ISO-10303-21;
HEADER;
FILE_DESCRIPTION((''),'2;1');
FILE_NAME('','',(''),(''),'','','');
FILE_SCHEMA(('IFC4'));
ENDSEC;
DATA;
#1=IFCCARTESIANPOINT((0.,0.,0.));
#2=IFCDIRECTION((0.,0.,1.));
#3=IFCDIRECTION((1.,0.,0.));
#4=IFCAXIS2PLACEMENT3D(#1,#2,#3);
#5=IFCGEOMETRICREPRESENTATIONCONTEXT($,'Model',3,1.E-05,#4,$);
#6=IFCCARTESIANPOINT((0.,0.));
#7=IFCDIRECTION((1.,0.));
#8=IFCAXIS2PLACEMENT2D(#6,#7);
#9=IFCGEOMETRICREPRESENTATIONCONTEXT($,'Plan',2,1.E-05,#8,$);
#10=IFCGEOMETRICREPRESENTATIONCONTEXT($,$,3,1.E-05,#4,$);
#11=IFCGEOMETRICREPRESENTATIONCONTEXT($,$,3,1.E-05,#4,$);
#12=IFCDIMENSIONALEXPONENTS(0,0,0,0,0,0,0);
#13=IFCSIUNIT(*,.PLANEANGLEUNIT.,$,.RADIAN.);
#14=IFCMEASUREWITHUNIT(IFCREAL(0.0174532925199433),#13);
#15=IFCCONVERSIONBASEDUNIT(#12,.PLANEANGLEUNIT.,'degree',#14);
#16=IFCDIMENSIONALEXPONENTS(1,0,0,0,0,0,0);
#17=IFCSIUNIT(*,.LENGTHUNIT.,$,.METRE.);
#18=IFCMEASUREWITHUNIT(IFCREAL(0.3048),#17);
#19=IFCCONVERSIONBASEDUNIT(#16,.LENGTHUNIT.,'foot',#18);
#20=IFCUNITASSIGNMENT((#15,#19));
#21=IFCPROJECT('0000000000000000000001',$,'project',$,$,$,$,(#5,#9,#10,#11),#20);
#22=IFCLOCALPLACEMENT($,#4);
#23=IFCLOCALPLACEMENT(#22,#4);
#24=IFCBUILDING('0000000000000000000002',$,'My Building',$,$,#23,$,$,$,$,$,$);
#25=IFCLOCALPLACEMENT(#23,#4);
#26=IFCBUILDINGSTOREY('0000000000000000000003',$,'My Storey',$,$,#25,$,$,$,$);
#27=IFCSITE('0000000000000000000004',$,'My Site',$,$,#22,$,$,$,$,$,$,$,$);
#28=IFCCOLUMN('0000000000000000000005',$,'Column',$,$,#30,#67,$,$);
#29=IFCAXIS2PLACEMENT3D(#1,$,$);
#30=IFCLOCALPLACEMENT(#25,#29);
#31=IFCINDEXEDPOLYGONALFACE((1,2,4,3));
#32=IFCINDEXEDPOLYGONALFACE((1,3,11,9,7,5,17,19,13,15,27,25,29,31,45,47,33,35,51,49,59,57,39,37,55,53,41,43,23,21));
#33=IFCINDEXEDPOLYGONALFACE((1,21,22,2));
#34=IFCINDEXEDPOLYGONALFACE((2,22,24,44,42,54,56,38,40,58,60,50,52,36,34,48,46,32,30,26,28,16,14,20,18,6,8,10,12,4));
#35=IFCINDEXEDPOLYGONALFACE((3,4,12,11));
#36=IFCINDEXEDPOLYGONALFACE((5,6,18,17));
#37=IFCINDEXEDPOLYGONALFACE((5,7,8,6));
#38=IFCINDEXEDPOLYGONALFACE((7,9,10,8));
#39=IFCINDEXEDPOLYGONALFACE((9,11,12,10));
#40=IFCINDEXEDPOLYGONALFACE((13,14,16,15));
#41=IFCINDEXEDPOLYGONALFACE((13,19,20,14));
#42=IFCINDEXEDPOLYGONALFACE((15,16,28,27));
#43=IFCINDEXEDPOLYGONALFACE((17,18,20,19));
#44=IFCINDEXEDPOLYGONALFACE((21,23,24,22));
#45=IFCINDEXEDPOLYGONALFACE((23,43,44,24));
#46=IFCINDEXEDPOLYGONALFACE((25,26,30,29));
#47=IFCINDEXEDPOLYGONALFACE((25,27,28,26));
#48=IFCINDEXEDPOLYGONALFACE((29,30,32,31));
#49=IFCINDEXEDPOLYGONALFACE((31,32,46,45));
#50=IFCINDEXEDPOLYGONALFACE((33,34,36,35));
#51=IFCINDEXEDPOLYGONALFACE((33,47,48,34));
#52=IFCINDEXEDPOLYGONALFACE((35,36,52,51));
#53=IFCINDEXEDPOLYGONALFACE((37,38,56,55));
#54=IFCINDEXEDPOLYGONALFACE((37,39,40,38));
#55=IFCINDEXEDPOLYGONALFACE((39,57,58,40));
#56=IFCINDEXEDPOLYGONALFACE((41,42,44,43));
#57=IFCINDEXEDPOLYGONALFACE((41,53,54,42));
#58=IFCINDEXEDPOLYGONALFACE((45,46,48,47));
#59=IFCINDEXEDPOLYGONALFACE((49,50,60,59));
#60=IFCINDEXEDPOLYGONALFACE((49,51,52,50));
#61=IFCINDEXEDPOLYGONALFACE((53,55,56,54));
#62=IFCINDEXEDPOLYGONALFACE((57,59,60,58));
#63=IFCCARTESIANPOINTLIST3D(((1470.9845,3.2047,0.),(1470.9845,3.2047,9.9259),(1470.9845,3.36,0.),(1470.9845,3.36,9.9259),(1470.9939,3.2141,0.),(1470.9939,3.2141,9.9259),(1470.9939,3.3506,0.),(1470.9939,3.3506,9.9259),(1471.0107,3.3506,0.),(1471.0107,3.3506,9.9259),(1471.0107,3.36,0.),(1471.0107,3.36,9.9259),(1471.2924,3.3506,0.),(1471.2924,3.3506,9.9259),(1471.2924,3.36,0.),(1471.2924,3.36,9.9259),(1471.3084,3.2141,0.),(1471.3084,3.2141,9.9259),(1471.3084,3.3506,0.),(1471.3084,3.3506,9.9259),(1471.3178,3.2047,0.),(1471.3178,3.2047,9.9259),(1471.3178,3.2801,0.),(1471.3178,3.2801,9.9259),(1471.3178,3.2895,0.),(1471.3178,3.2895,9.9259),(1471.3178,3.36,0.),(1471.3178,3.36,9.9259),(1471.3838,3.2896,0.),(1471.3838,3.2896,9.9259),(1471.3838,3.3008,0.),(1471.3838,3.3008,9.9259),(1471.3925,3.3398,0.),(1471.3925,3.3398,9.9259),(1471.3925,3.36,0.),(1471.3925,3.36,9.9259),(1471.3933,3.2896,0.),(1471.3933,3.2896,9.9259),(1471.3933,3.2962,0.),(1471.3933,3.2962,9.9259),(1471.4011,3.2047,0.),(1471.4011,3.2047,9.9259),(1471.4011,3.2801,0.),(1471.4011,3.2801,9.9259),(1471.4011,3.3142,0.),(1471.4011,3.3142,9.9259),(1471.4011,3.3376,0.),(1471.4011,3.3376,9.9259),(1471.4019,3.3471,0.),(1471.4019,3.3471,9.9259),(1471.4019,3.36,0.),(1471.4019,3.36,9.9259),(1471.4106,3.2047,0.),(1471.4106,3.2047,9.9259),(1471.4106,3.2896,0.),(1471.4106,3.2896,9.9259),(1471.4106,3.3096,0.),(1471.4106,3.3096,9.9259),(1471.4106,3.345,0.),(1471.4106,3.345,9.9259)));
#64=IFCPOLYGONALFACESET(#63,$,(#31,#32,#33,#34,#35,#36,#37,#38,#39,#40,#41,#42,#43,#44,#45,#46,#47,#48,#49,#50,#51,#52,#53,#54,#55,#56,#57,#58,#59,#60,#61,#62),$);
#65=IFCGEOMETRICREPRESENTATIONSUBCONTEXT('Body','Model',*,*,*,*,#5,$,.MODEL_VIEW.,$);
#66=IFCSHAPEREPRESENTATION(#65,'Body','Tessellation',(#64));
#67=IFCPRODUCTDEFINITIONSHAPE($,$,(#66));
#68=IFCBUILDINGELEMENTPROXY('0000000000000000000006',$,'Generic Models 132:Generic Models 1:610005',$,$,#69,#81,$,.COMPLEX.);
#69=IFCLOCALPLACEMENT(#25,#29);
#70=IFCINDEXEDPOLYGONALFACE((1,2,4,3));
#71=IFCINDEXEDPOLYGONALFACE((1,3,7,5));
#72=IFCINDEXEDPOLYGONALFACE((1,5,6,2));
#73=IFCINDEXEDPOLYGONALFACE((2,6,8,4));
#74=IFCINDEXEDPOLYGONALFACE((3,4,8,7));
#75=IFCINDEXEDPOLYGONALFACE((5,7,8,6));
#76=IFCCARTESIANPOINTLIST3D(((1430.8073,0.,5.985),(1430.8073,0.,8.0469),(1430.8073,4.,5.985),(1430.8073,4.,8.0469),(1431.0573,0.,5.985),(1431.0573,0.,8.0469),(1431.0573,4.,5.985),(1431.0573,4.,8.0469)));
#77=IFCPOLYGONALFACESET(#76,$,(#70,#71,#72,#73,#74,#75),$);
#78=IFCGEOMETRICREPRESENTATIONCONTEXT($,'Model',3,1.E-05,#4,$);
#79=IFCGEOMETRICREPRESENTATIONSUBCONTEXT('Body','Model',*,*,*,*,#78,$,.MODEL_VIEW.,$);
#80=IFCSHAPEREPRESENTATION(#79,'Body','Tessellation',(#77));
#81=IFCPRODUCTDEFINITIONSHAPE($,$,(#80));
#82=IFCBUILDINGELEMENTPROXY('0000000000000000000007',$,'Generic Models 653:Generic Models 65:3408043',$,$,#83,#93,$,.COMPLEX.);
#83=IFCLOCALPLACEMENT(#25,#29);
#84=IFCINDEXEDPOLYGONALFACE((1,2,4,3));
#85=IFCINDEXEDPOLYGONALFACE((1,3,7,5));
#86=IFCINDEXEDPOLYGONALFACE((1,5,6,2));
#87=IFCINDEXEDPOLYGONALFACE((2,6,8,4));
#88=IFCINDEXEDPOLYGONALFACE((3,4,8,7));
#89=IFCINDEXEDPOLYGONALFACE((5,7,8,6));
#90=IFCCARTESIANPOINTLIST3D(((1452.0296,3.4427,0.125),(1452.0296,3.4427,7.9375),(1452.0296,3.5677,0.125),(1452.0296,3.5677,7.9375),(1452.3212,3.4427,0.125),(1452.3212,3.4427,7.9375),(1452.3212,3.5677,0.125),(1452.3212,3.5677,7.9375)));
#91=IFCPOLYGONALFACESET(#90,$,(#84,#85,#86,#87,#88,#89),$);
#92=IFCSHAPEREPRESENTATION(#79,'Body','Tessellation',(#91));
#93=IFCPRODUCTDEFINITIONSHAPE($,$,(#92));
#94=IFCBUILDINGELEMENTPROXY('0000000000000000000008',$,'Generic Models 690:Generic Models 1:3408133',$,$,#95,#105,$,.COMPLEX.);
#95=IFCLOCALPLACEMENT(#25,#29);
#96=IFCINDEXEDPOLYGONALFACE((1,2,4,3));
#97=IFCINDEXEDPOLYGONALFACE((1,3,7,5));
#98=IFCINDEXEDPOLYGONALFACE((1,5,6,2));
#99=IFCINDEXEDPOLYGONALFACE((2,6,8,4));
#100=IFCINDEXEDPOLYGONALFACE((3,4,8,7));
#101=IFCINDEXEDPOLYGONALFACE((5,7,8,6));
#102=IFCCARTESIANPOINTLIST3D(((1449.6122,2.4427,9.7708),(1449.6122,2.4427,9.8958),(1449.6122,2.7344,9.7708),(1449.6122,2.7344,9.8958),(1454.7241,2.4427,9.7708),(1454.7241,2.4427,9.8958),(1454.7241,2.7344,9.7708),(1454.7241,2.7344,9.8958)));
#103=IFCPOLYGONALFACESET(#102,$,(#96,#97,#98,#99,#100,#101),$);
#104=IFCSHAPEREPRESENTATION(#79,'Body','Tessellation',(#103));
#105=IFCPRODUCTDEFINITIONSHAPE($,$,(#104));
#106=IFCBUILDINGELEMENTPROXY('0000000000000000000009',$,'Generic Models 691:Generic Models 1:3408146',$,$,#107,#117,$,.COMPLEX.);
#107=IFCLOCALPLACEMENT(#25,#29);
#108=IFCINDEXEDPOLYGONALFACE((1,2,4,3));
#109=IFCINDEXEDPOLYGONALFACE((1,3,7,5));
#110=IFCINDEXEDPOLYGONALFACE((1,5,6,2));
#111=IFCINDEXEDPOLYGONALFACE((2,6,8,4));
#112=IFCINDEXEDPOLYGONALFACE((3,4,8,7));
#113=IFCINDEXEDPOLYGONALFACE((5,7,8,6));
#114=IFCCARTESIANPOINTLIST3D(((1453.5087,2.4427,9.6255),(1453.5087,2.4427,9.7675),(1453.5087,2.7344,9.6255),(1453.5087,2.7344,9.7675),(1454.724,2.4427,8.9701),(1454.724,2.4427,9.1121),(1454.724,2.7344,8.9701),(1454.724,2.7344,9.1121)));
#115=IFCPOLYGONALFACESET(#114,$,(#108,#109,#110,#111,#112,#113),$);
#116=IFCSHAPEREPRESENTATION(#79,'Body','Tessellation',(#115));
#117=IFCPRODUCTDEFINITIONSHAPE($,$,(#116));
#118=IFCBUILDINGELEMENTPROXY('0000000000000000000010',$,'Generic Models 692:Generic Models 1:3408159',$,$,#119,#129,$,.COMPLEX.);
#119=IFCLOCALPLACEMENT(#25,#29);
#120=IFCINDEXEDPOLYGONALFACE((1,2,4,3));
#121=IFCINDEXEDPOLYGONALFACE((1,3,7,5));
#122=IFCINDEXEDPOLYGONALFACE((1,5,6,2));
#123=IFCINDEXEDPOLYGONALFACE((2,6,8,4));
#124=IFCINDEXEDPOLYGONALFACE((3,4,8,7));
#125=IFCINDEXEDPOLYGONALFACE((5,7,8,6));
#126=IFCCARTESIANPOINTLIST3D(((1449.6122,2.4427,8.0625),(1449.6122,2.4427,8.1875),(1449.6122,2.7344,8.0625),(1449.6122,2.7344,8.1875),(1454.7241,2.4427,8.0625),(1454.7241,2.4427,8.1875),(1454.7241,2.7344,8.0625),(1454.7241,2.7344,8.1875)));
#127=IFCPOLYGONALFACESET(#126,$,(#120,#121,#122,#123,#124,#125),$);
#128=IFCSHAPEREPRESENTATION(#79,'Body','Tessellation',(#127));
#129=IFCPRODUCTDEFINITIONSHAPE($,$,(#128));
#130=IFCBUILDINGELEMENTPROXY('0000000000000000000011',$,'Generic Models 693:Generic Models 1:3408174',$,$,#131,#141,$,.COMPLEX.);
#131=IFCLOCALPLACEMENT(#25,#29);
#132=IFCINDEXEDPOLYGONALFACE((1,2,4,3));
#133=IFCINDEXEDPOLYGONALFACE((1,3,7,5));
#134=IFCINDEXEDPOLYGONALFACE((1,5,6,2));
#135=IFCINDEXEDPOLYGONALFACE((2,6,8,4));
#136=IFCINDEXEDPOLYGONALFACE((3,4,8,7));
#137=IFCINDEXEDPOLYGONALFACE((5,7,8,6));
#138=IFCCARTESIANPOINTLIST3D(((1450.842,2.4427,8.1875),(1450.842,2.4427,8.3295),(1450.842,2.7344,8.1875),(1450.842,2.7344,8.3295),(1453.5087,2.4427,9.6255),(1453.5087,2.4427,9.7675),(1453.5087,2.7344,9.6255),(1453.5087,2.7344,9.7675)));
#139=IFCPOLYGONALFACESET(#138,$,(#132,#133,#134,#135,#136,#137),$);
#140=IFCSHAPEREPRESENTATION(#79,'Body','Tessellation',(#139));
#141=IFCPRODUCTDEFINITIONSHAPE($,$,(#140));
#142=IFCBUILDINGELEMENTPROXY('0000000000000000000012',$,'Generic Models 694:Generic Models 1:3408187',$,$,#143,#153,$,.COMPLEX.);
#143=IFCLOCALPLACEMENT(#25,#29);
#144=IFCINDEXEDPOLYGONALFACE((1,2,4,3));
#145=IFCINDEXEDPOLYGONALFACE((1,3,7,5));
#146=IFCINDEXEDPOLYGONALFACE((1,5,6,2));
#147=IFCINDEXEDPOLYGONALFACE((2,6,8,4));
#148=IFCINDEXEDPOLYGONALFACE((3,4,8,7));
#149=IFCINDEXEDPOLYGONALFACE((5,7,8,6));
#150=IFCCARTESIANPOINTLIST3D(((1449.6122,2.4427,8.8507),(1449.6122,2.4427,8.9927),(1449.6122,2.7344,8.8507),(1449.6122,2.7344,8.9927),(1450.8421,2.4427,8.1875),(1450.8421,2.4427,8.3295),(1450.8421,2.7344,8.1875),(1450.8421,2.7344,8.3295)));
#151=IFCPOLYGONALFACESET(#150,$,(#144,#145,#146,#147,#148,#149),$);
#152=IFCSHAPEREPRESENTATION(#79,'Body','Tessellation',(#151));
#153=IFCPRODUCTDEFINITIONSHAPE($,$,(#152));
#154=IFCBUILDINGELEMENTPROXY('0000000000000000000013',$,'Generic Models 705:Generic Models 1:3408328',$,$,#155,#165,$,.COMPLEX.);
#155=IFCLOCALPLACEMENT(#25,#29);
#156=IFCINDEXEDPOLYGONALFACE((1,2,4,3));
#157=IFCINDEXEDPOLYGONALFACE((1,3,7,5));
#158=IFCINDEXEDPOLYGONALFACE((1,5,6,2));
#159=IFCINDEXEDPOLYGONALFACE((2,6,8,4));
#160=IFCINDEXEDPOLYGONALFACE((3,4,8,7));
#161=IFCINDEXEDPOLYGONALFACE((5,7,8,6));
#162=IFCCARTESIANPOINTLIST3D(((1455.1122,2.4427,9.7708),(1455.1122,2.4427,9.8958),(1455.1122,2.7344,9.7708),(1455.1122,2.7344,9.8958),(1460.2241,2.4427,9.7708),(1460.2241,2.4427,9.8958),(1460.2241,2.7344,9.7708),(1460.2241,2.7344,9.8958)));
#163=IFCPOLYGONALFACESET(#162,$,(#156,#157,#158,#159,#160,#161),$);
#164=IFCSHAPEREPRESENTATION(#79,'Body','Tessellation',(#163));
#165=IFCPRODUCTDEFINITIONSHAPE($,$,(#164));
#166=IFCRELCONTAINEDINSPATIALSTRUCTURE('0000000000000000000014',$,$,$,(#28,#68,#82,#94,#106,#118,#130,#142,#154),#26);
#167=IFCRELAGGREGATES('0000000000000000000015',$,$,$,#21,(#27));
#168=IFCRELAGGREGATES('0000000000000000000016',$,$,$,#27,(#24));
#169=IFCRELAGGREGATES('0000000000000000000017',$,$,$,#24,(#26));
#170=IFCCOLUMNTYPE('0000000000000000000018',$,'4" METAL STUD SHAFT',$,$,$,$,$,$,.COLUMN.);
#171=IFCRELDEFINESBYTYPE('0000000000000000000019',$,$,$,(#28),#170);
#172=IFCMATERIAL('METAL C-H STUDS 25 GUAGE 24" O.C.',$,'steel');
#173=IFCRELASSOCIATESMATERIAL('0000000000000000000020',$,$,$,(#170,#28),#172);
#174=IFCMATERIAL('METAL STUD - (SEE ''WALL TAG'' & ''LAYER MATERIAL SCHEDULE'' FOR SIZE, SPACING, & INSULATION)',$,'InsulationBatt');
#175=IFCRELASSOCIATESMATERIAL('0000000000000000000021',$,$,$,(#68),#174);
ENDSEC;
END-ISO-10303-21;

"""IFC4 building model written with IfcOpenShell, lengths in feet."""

from ifc_helpers import new_model, entity, si_unit, converted_unit, frame, origin_with_axes, origin_2d_with_axis, place, context, subcontext, project, spatial, polyline, line, indexed_curve, outline, extrude, material, material_profile, profile_set, profile_usage, type_object, element, save


model = new_model("IFC4")

# Units and contexts
model_context_1 = context("Model", 3, precision=1e-05, world=origin_with_axes())
plan_context = context("Plan", 2, precision=1e-05, world=origin_2d_with_axis())
model_context_2 = context("Model", 3, precision=1e-05, world=origin_with_axes())
context_of_model_1 = context(None, 3, precision=1e-05, world=origin_with_axes())
context_of_model_2 = context(None, 3, precision=1e-05, world=origin_with_axes())
body_context_1 = subcontext(model_context_1, "Body", "Model", "MODEL_VIEW")
body_context_2 = subcontext(model_context_2, "Body", "Model", "MODEL_VIEW")
ifc_project = project(units=[converted_unit("PLANEANGLEUNIT", "degree", entity("IfcReal", 0.0174532925199433), si_unit("PLANEANGLEUNIT", "RADIAN"), dimensions=[0, 0, 0, 0, 0, 0, 0]), converted_unit("LENGTHUNIT", "foot", entity("IfcReal", 0.3048), si_unit("LENGTHUNIT", "METRE"), dimensions=[1, 0, 0, 0, 0, 0, 0])], contexts=[model_context_1, plan_context, context_of_model_1, context_of_model_2])

# Site, building, storey
site_placement = place(None, origin_with_axes())
site = spatial("IfcSite", under=ifc_project, at=site_placement, Name="My Site")
building_placement = place(site_placement, origin_with_axes())
building = spatial("IfcBuilding", under=site, at=building_placement, Name="My Building")
storey_placement = place(building_placement, origin_with_axes())
storey = spatial("IfcBuildingStorey", under=building, at=storey_placement, Name="My Storey")

# Column
ifc_material_1 = material(Name="METAL C-H STUDS 25 GUAGE 24\" O.C.", Category="steel")
ifc_material_profile = material_profile(ifc_material_1, outline(indexed_curve([(0.4088, 0.0849), (0.4261, 0.0849), (0.4261, 0.0), (0.4166, 0.0), (0.4166, 0.0754), (0.3333, 0.0754), (0.3333, 0.0), (0.0, 0.0), (0.0, 0.1553), (0.0262, 0.1553), (0.0262, 0.1459), (0.0094, 0.1459), (0.0094, 0.0094), (0.3239, 0.0094), (0.3239, 0.1459), (0.3079, 0.1459), (0.3079, 0.1553), (0.3333, 0.1553), (0.3333, 0.0848), (0.3993, 0.0849), (0.3993, 0.0961), (0.4166, 0.1095), (0.4166, 0.1329), (0.408, 0.1351), (0.408, 0.1553), (0.4174, 0.1553), (0.4174, 0.1424), (0.4261, 0.1403), (0.4261, 0.1049), (0.4088, 0.0915)], segments=[line(24, 23), line(23, 22), line(22, 21), line(21, 20), line(20, 19), line(19, 18), line(18, 17), line(17, 16), line(16, 15), line(15, 14), line(14, 13), line(13, 12), line(12, 11), line(11, 10), line(10, 9), line(9, 8), line(8, 7), line(7, 6), line(6, 5), line(5, 4), line(4, 3), line(3, 2), line(2, 1), line(1, 30), line(30, 29), line(29, 28), line(28, 27), line(27, 26), line(26, 25), line(25, 24)], self_intersect=False)))
ifc_profile_set = profile_set([ifc_material_profile])
ifc_profile_usage = profile_usage(ifc_profile_set)
column_type = type_object("IfcColumnType", Name="4\" METAL STUD SHAFT", PredefinedType="COLUMN", material=ifc_profile_set)
column_placement = place(storey_placement, frame((1470.9845, 3.2047, 0.0), z_axis=(0.0, 0.0, 1.0), x_axis=(1.0, 0.0, 0.0)))
element("IfcColumn", 1, at=column_placement, inside=storey, type_object=column_type, material=ifc_profile_usage, Name="Column", context=body_context_1, shape_type="SweptSolid", body=[
    extrude(outline(indexed_curve([(0.4088, 0.0849), (0.4261, 0.0849), (0.4261, 0.0), (0.4166, 0.0), (0.4166, 0.0754), (0.3333, 0.0754), (0.3333, 0.0), (0.0, 0.0), (0.0, 0.1553), (0.0262, 0.1553), (0.0262, 0.1459), (0.0094, 0.1459), (0.0094, 0.0094), (0.3239, 0.0094), (0.3239, 0.1459), (0.3079, 0.1459), (0.3079, 0.1553), (0.3333, 0.1553), (0.3333, 0.0848), (0.3993, 0.0849), (0.3993, 0.0961), (0.4166, 0.1095), (0.4166, 0.1329), (0.408, 0.1351), (0.408, 0.1553), (0.4174, 0.1553), (0.4174, 0.1424), (0.4261, 0.1403), (0.4261, 0.1049), (0.4088, 0.0915)], segments=[line(24, 23), line(23, 22), line(22, 21), line(21, 20), line(20, 19), line(19, 18), line(18, 17), line(17, 16), line(16, 15), line(15, 14), line(14, 13), line(13, 12), line(12, 11), line(11, 10), line(10, 9), line(9, 8), line(8, 7), line(7, 6), line(6, 5), line(5, 4), line(4, 3), line(3, 2), line(2, 1), line(1, 30), line(30, 29), line(29, 28), line(28, 27), line(27, 26), line(26, 25), line(25, 24)], self_intersect=False)), origin_with_axes(), (0.0, 0.0, 1.0), 9.9259),
])

# Building element proxies
ifc_material_2 = material(Name="METAL STUD - (SEE 'WALL TAG' & 'LAYER MATERIAL SCHEDULE' FOR SIZE, SPACING, & INSULATION)", Category="InsulationBatt")
proxy_1_placement = place(storey_placement, frame((1430.8073, 4.0, 5.985), z_axis=(0.0, -1.0, 0.0), x_axis=(0.0, 0.0, 1.0)))
element("IfcBuildingElementProxy", 2, at=proxy_1_placement, inside=storey, material=ifc_material_2, Name="Generic Models 132:Generic Models 1:610005", PredefinedType="COMPLEX", context=body_context_2, shape_type="SweptSolid", body=[
    extrude(outline(polyline([(-1.0309, -0.125), (1.0309, -0.125), (1.0309, 0.125), (-1.0309, 0.125), (-1.0309, -0.125)])), frame((1.0309, -0.125, 0.0), z_axis=(0.0, 0.0, -1.0), x_axis=(1.0, 0.0, 0.0)), (0.0, 0.0, -1.0), 4.0),
])
proxy_2_placement = place(storey_placement, frame((1452.0296, 3.4427, 0.125), z_axis=(0.0, 0.0, 1.0), x_axis=(1.0, 0.0, 0.0)))
element("IfcBuildingElementProxy", 3, at=proxy_2_placement, inside=storey, Name="Generic Models 653:Generic Models 65:3408043", PredefinedType="COMPLEX", context=body_context_2, shape_type="SweptSolid", body=[
    extrude(outline(polyline([(-0.1458, -0.0625), (0.1458, -0.0625), (0.1458, 0.0625), (-0.1458, 0.0625), (-0.1458, -0.0625)])), frame((0.1458, 0.0625, 0.0), z_axis=(0.0, 0.0, -1.0), x_axis=(-1.0, 0.0, 0.0)), (0.0, 0.0, -1.0), 7.8125),
])
proxy_3_placement = place(storey_placement, frame((1449.6122, 2.7344, 9.7708), z_axis=(0.0, -1.0, 0.0), x_axis=(1.0, 0.0, 0.0)))
element("IfcBuildingElementProxy", 4, at=proxy_3_placement, inside=storey, Name="Generic Models 690:Generic Models 1:3408133", PredefinedType="COMPLEX", context=body_context_2, shape_type="SweptSolid", body=[
    extrude(outline(polyline([(-0.0625, -2.556), (0.0625, -2.556), (0.0625, 2.556), (-0.0625, 2.556), (-0.0625, -2.556)])), frame((2.556, 0.0625, 0.0), z_axis=(0.0, 0.0, -1.0), x_axis=(0.0, 1.0, 0.0)), (0.0, 0.0, -1.0), 0.2917),
])
proxy_4_placement = place(storey_placement, frame((1453.5087, 2.7344, 8.9701), z_axis=(0.0, -1.0, 0.0), x_axis=(1.0, 0.0, 0.0)))
element("IfcBuildingElementProxy", 5, at=proxy_4_placement, inside=storey, Name="Generic Models 691:Generic Models 1:3408146", PredefinedType="COMPLEX", context=body_context_2, shape_type="SweptSolid", body=[
    extrude(outline(polyline([(0.2567, -0.6077), (0.3987, -0.6077), (-0.2567, 0.6077), (-0.3987, 0.6077), (0.2567, -0.6077)])), frame((0.6077, 0.3987, 0.0), z_axis=(0.0, 0.0, -1.0), x_axis=(0.0, 1.0, 0.0)), (0.0, 0.0, -1.0), 0.2917),
])
proxy_5_placement = place(storey_placement, frame((1449.6122, 2.7344, 8.0625), z_axis=(0.0, -1.0, 0.0), x_axis=(1.0, 0.0, 0.0)))
element("IfcBuildingElementProxy", 6, at=proxy_5_placement, inside=storey, Name="Generic Models 692:Generic Models 1:3408159", PredefinedType="COMPLEX", context=body_context_2, shape_type="SweptSolid", body=[
    extrude(outline(polyline([(-0.0625, -2.556), (0.0625, -2.556), (0.0625, 2.556), (-0.0625, 2.556), (-0.0625, -2.556)])), frame((2.556, 0.0625, 0.0), z_axis=(0.0, 0.0, -1.0), x_axis=(0.0, 1.0, 0.0)), (0.0, 0.0, -1.0), 0.2917),
])
proxy_6_placement = place(storey_placement, frame((1450.842, 2.7344, 8.1875), z_axis=(0.0, -1.0, 0.0), x_axis=(1.0, 0.0, 0.0)))
element("IfcBuildingElementProxy", 7, at=proxy_6_placement, inside=storey, Name="Generic Models 693:Generic Models 1:3408174", PredefinedType="COMPLEX", context=body_context_2, shape_type="SweptSolid", body=[
    extrude(outline(polyline([(-0.79, -1.3333), (-0.648, -1.3333), (0.79, 1.3333), (0.648, 1.3333), (-0.79, -1.3333)])), frame((1.3333, 0.79, 0.0), z_axis=(0.0, 0.0, -1.0), x_axis=(0.0, -1.0, 0.0)), (0.0, 0.0, -1.0), 0.2917),
])
proxy_7_placement = place(storey_placement, frame((1449.6122, 2.7344, 8.1875), z_axis=(0.0, -1.0, 0.0), x_axis=(1.0, 0.0, 0.0)))
element("IfcBuildingElementProxy", 8, at=proxy_7_placement, inside=storey, Name="Generic Models 694:Generic Models 1:3408187", PredefinedType="COMPLEX", context=body_context_2, shape_type="SweptSolid", body=[
    extrude(outline(polyline([(0.2606, -0.6149), (0.4026, -0.6149), (-0.2606, 0.6149), (-0.4026, 0.6149), (0.2606, -0.6149)])), frame((0.6149, 0.4026, 0.0), z_axis=(0.0, 0.0, -1.0), x_axis=(0.0, 1.0, 0.0)), (0.0, 0.0, -1.0), 0.2917),
])
proxy_8_placement = place(storey_placement, frame((1455.1122, 2.7344, 9.7708), z_axis=(0.0, -1.0, 0.0), x_axis=(1.0, 0.0, 0.0)))
element("IfcBuildingElementProxy", 9, at=proxy_8_placement, inside=storey, Name="Generic Models 705:Generic Models 1:3408328", PredefinedType="COMPLEX", context=body_context_2, shape_type="SweptSolid", body=[
    extrude(outline(polyline([(-0.0625, -2.556), (0.0625, -2.556), (0.0625, 2.556), (-0.0625, 2.556), (-0.0625, -2.556)])), frame((2.556, 0.0625, 0.0), z_axis=(0.0, 0.0, -1.0), x_axis=(0.0, 1.0, 0.0)), (0.0, 0.0, -1.0), 0.2917),
])

save(model, "model.ifc")
